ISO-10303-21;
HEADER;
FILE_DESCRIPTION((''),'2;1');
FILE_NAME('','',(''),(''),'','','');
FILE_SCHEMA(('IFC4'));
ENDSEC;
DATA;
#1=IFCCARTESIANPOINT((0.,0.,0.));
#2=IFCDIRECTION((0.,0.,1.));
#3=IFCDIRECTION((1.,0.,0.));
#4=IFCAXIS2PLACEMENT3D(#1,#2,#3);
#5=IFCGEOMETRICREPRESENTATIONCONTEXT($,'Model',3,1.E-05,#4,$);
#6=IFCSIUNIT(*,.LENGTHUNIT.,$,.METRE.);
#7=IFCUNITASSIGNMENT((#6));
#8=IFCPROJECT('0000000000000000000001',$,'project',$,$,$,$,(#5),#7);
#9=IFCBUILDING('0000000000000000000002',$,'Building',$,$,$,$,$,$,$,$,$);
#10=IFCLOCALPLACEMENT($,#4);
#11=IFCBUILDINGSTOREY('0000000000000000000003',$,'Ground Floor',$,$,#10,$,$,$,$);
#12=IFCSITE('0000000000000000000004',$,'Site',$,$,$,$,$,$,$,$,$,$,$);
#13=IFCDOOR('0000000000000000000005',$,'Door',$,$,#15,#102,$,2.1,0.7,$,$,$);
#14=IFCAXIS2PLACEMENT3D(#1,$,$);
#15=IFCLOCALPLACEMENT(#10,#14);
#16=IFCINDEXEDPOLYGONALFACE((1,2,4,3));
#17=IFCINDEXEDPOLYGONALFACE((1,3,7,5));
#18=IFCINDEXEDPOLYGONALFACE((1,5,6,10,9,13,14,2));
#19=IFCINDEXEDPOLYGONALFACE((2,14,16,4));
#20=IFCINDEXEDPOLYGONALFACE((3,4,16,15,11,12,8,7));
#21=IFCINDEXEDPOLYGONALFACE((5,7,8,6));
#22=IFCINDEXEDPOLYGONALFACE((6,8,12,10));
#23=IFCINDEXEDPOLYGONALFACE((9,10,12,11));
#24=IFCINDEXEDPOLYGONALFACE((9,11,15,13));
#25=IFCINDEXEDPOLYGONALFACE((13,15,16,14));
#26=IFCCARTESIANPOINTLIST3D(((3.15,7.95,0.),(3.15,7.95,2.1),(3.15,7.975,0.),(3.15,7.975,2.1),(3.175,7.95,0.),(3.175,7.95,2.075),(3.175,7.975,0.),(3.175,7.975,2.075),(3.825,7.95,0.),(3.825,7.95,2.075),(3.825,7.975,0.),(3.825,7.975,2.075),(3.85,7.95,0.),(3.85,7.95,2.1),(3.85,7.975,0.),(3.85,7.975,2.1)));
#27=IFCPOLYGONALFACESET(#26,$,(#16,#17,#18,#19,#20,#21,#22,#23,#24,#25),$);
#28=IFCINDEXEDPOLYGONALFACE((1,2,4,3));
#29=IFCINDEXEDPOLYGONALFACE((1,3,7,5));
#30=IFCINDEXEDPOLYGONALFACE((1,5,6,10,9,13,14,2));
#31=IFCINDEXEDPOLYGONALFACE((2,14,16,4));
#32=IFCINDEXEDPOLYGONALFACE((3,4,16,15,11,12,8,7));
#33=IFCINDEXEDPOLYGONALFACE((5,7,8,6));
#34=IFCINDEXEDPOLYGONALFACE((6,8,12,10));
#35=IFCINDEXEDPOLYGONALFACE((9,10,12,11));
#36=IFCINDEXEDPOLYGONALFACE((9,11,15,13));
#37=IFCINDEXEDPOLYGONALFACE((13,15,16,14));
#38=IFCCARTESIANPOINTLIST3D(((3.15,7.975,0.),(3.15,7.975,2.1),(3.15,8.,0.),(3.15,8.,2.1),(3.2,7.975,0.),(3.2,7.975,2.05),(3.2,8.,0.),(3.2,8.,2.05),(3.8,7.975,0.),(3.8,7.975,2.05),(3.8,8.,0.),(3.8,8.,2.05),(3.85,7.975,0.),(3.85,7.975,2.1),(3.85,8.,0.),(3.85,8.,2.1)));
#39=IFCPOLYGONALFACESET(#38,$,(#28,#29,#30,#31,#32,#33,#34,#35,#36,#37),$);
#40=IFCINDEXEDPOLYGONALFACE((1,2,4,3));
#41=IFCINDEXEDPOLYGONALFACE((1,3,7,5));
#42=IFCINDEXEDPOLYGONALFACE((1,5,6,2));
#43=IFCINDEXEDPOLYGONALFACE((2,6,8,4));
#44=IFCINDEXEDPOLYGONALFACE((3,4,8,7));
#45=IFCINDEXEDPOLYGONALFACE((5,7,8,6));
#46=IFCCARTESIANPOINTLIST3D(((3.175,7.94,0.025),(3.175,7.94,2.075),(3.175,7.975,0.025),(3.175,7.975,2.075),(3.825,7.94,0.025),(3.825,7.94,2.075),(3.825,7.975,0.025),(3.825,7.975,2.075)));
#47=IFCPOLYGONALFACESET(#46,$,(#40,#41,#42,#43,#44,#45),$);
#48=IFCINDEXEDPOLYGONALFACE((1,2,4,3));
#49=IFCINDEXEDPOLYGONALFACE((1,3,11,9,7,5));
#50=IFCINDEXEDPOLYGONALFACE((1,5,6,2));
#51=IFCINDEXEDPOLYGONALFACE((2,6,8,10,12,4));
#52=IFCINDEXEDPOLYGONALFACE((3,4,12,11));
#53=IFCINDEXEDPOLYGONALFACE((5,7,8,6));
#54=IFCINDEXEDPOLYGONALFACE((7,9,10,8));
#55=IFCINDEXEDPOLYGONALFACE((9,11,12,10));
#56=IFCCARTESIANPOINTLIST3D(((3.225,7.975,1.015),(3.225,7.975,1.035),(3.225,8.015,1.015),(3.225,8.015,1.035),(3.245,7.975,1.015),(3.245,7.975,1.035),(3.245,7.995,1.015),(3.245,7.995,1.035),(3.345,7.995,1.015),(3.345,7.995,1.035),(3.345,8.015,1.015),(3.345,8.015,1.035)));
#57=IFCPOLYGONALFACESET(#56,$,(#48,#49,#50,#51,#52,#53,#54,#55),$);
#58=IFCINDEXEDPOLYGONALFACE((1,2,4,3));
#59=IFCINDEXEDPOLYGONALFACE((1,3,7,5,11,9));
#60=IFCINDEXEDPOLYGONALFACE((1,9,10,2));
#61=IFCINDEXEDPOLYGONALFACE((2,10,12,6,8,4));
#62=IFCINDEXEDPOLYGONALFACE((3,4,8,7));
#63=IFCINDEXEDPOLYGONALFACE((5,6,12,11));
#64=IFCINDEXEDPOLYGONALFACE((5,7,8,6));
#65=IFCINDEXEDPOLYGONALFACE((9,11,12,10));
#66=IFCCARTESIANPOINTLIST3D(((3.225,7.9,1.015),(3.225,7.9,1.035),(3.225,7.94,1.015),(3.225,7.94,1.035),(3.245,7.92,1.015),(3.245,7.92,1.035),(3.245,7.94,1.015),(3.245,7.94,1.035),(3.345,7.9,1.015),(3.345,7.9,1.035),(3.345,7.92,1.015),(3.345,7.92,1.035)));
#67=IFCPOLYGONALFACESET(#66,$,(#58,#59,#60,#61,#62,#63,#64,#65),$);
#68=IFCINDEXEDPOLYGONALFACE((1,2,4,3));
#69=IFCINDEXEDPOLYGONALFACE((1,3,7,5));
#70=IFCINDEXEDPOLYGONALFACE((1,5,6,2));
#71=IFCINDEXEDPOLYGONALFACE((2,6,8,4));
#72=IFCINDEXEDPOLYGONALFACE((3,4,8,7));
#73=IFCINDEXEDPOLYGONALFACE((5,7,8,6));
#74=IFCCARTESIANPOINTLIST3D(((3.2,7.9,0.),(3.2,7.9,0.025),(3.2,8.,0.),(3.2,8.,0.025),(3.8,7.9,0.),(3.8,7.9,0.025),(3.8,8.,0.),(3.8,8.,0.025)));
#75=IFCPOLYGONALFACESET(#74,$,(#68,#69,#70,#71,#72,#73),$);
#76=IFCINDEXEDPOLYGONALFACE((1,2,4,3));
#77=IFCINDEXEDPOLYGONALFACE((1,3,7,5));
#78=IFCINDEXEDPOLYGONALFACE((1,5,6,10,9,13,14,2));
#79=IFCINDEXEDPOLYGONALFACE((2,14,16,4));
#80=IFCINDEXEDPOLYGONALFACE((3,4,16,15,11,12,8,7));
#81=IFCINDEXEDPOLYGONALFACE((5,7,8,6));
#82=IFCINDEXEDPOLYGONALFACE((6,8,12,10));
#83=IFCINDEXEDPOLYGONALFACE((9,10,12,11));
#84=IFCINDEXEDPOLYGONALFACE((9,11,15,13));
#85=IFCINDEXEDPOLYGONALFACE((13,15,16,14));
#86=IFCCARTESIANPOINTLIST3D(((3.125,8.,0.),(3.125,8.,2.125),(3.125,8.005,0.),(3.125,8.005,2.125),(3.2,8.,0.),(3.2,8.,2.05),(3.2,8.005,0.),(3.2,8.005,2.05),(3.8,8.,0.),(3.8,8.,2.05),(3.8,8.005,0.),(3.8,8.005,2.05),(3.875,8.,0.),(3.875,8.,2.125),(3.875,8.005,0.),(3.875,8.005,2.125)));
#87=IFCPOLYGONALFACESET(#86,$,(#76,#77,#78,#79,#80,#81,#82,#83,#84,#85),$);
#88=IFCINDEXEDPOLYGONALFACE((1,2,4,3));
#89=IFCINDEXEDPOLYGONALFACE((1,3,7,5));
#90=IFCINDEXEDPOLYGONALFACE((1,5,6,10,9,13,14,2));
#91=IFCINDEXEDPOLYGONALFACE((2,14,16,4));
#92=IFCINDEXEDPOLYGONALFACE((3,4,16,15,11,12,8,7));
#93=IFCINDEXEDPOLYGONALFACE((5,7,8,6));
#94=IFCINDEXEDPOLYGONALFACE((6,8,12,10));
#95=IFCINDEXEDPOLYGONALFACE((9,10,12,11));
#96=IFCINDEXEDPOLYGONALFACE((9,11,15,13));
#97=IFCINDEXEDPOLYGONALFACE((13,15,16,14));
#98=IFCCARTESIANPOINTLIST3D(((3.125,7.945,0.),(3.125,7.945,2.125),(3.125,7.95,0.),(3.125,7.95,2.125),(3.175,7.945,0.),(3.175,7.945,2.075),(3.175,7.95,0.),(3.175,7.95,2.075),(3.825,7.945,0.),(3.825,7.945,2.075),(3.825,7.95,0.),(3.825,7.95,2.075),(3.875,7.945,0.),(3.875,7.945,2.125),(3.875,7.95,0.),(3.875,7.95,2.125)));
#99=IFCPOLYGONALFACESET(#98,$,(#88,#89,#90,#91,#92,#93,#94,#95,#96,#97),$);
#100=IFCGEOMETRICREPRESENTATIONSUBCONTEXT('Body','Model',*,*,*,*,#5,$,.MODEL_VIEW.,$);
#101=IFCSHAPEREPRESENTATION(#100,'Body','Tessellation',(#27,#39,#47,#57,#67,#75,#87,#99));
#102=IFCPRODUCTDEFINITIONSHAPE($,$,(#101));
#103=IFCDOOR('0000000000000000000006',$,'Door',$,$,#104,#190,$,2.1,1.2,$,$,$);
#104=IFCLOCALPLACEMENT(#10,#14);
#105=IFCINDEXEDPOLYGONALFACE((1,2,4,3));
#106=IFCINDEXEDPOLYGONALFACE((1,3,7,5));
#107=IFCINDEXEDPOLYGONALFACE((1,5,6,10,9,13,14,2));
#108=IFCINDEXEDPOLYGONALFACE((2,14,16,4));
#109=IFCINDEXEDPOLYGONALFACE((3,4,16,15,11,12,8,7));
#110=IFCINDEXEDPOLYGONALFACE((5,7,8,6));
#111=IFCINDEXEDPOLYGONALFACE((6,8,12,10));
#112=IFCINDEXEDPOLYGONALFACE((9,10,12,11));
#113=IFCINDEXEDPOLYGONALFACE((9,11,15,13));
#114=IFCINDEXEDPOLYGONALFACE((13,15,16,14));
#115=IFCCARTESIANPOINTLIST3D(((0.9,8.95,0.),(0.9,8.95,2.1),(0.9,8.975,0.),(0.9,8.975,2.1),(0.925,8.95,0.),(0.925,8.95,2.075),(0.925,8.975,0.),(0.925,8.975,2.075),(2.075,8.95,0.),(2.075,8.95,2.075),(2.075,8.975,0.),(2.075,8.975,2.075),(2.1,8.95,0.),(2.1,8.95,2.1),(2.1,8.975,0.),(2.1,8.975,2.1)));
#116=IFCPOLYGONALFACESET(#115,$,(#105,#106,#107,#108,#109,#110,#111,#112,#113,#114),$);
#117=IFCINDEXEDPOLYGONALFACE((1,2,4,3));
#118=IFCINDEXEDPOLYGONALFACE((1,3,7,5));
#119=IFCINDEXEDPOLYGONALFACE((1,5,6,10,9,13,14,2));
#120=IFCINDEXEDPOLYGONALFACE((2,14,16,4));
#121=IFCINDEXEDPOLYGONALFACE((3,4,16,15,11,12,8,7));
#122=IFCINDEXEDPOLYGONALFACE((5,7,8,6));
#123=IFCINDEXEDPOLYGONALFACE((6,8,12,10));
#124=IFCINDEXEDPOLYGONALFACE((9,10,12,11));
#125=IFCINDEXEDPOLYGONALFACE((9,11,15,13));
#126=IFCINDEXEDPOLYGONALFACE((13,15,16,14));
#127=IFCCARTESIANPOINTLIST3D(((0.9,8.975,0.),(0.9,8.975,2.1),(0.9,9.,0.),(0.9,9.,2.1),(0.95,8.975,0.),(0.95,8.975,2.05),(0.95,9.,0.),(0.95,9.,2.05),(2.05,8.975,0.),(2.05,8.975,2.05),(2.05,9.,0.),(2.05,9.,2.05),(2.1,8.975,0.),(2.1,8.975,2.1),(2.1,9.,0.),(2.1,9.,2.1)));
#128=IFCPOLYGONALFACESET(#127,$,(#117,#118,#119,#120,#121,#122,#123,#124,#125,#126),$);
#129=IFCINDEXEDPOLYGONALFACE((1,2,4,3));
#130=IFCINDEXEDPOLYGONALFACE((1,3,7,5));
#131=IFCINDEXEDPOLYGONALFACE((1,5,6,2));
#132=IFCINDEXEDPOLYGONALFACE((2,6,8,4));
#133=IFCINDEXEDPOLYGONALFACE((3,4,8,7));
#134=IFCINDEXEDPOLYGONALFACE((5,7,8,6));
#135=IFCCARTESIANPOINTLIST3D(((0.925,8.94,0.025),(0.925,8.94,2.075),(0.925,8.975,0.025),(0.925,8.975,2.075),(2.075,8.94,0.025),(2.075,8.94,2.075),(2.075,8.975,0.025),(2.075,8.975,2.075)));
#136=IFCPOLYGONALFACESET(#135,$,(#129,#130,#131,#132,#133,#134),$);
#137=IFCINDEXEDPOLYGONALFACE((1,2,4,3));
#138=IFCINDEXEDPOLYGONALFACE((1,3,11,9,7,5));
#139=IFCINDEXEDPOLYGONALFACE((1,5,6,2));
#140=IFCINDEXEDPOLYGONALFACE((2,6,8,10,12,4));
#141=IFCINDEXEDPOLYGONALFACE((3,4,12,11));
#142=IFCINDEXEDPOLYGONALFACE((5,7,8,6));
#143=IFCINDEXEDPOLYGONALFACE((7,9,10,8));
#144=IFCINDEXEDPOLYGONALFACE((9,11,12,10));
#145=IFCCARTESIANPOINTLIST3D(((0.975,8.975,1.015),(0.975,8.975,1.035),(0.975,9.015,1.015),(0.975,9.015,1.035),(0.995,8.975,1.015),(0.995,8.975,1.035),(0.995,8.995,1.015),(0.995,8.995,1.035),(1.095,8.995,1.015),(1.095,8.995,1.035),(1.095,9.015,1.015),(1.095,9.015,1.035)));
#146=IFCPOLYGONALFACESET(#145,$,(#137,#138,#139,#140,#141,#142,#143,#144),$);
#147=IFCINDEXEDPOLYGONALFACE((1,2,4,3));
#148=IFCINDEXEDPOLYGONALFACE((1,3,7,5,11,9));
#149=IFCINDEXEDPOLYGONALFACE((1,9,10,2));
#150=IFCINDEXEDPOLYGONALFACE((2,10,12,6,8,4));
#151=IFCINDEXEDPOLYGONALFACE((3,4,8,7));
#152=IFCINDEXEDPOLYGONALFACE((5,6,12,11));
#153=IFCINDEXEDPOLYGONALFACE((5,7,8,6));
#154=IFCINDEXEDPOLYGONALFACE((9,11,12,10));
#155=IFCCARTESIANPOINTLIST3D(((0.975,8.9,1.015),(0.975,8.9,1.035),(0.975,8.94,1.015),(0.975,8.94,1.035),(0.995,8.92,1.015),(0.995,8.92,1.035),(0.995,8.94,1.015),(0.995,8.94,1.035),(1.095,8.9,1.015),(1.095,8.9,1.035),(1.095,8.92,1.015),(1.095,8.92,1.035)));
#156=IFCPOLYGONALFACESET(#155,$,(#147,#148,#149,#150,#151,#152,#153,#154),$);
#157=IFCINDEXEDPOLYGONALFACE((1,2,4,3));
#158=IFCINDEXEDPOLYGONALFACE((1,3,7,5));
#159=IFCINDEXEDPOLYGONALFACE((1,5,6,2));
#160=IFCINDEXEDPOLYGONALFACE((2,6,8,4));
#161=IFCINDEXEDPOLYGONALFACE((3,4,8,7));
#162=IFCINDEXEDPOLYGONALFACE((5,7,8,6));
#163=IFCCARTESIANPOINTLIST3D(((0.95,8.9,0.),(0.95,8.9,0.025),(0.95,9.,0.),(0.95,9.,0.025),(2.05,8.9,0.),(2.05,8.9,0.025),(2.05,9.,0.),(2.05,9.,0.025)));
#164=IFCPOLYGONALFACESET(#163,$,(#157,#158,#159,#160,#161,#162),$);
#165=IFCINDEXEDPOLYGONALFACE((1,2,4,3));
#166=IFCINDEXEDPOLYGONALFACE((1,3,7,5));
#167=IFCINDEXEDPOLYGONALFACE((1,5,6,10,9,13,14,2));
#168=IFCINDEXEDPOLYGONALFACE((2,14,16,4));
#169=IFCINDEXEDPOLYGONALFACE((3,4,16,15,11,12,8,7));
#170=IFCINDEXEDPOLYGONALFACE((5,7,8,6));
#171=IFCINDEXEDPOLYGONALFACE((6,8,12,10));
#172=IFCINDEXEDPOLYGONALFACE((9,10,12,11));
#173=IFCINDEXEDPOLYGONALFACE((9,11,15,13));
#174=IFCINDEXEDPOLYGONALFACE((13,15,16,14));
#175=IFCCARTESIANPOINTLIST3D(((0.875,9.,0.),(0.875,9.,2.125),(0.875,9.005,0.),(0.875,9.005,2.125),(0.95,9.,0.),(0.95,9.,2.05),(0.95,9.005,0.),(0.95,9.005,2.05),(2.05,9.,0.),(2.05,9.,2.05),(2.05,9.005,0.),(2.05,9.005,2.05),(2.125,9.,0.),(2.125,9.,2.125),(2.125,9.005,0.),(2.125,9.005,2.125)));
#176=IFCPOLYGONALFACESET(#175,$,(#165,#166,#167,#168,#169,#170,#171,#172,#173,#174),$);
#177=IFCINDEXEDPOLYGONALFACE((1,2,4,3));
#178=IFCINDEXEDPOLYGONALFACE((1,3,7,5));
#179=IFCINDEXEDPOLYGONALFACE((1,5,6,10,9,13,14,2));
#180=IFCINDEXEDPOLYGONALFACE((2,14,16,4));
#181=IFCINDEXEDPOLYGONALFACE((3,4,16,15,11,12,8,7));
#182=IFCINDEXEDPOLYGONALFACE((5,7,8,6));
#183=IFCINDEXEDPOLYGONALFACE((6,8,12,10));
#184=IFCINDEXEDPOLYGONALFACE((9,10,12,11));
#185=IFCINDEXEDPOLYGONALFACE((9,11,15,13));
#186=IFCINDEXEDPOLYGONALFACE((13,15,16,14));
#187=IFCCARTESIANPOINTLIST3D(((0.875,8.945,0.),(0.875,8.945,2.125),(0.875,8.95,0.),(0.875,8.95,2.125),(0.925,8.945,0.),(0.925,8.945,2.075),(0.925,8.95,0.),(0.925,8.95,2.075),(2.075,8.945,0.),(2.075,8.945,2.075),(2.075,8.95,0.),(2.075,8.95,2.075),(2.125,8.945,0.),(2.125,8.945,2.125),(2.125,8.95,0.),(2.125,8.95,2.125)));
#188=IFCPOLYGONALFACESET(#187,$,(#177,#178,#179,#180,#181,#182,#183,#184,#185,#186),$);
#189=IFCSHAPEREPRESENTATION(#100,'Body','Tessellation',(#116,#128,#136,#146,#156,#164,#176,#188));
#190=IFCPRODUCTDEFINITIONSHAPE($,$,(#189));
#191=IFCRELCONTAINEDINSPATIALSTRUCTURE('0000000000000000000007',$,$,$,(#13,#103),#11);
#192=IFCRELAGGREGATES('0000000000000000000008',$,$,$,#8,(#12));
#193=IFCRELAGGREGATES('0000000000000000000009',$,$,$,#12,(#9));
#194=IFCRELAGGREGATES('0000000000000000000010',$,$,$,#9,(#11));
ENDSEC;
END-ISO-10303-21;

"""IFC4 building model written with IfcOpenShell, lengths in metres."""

from ifc_helpers import new_model, si_unit, frame, origin_with_axes, place, context, subcontext, project, spatial, line, indexed_curve, outline, extrude, element, save


model = new_model("IFC4")

# Units and contexts
model_context = context("Model", 3, precision=1e-05, world=origin_with_axes())
body_context = subcontext(model_context, "Body", "Model", "MODEL_VIEW")
ifc_project = project(units=[si_unit("LENGTHUNIT", "METRE")], contexts=[model_context])

# Site, building, storey
site = spatial("IfcSite", under=ifc_project, Name="Site")
building = spatial("IfcBuilding", under=site, Name="Building")
storey_placement = place(None, origin_with_axes())
storey = spatial("IfcBuildingStorey", under=building, at=storey_placement, Name="Ground Floor")

# Doors
door_1_placement = place(storey_placement, frame((3.85, 8.0, 0.0), z_axis=(0.0, 0.0, 1.0), x_axis=(-1.0, 0.0, 0.0)))
element("IfcDoor", 1, at=door_1_placement, inside=storey, Name="Door", OverallHeight=2.1, OverallWidth=0.7, context=body_context, shape_type="SweptSolid", body=[
    extrude(outline(indexed_curve([(0.0, 0.0), (0.0, 2.1), (0.7, 2.1), (0.7, 0.0), (0.675, 0.0), (0.675, 2.075), (0.025, 2.075), (0.025, 0.0)], segments=[line(1, 2, 3, 4, 5, 6, 7, 8, 1)])), frame((0.0, 0.025, 0.0), z_axis=(0.0, -1.0, 0.0), x_axis=(1.0, 0.0, 0.0)), (0.0, 0.0, -1.0), 0.025),
    extrude(outline(indexed_curve([(0.0, 0.0), (0.0, 2.1), (0.7, 2.1), (0.7, 0.0), (0.65, 0.0), (0.65, 2.05), (0.05, 2.05), (0.05, 0.0)], segments=[line(1, 2, 3, 4, 5, 6, 7, 8, 1)])), frame((0.0, 0.0, 0.0), z_axis=(0.0, -1.0, 0.0), x_axis=(1.0, 0.0, 0.0)), (0.0, 0.0, -1.0), 0.025),
    extrude(outline(indexed_curve([(0.0, 0.0), (0.65, 0.0), (0.65, 0.035), (0.0, 0.035)], segments=[line(1, 2, 3, 4, 1)])), frame((0.025, 0.025, 0.025), z_axis=(0.0, 0.0, 1.0), x_axis=(1.0, 0.0, 0.0)), (0.0, 0.0, 1.0), 2.05),
    extrude(outline(indexed_curve([(0.0, 0.0), (0.0, -0.04), (-0.12, -0.04), (-0.12, -0.02), (-0.02, -0.02), (-0.02, 0.0)], segments=[line(1, 2, 3, 4, 5, 6, 1)])), frame((0.625, 0.025, 1.015), z_axis=(0.0, 0.0, 1.0), x_axis=(1.0, 0.0, 0.0)), (0.0, 0.0, 1.0), 0.02),
    extrude(outline(indexed_curve([(0.0, 0.0), (0.0, 0.04), (-0.12, 0.04), (-0.12, 0.02), (-0.02, 0.02), (-0.02, 0.0)], segments=[line(1, 2, 3, 4, 5, 6, 1)])), frame((0.625, 0.06, 1.015), z_axis=(0.0, 0.0, 1.0), x_axis=(1.0, 0.0, 0.0)), (0.0, 0.0, 1.0), 0.02),
    extrude(outline(indexed_curve([(0.0, 0.0), (0.6, 0.0), (0.6, 0.1), (0.0, 0.1)], segments=[line(1, 2, 3, 4, 1)])), frame((0.05, 0.0, 0.0), z_axis=(0.0, 0.0, 1.0), x_axis=(1.0, 0.0, 0.0)), (0.0, 0.0, 1.0), 0.025),
    extrude(outline(indexed_curve([(0.0, 0.0), (0.0, 2.125), (0.75, 2.125), (0.75, 0.0), (0.675, 0.0), (0.675, 2.05), (0.075, 2.05), (0.075, 0.0)], segments=[line(1, 2, 3, 4, 5, 6, 7, 8, 1)])), frame((-0.025, -0.005, 0.0), z_axis=(0.0, -1.0, 0.0), x_axis=(1.0, 0.0, 0.0)), (0.0, 0.0, -1.0), 0.005),
    extrude(outline(indexed_curve([(0.0, 0.0), (0.0, 2.125), (0.75, 2.125), (0.75, 0.0), (0.7, 0.0), (0.7, 2.075), (0.05, 2.075), (0.05, 0.0)], segments=[line(1, 2, 3, 4, 5, 6, 7, 8, 1)])), frame((-0.025, 0.05, 0.0), z_axis=(0.0, -1.0, 0.0), x_axis=(1.0, 0.0, 0.0)), (0.0, 0.0, -1.0), 0.005),
])
door_2_placement = place(storey_placement, frame((2.1, 9.0, 0.0), z_axis=(0.0, 0.0, 1.0), x_axis=(-1.0, 0.0, 0.0)))
element("IfcDoor", 2, at=door_2_placement, inside=storey, Name="Door", OverallHeight=2.1, OverallWidth=1.2, context=body_context, shape_type="SweptSolid", body=[
    extrude(outline(indexed_curve([(0.0, 0.0), (0.0, 2.1), (1.2, 2.1), (1.2, 0.0), (1.175, 0.0), (1.175, 2.075), (0.025, 2.075), (0.025, 0.0)], segments=[line(1, 2, 3, 4, 5, 6, 7, 8, 1)])), frame((0.0, 0.025, 0.0), z_axis=(0.0, -1.0, 0.0), x_axis=(1.0, 0.0, 0.0)), (0.0, 0.0, -1.0), 0.025),
    extrude(outline(indexed_curve([(0.0, 0.0), (0.0, 2.1), (1.2, 2.1), (1.2, 0.0), (1.15, 0.0), (1.15, 2.05), (0.05, 2.05), (0.05, 0.0)], segments=[line(1, 2, 3, 4, 5, 6, 7, 8, 1)])), frame((0.0, 0.0, 0.0), z_axis=(0.0, -1.0, 0.0), x_axis=(1.0, 0.0, 0.0)), (0.0, 0.0, -1.0), 0.025),
    extrude(outline(indexed_curve([(0.0, 0.0), (1.15, 0.0), (1.15, 0.035), (0.0, 0.035)], segments=[line(1, 2, 3, 4, 1)])), frame((0.025, 0.025, 0.025), z_axis=(0.0, 0.0, 1.0), x_axis=(1.0, 0.0, 0.0)), (0.0, 0.0, 1.0), 2.05),
    extrude(outline(indexed_curve([(0.0, 0.0), (0.0, -0.04), (-0.12, -0.04), (-0.12, -0.02), (-0.02, -0.02), (-0.02, 0.0)], segments=[line(1, 2, 3, 4, 5, 6, 1)])), frame((1.125, 0.025, 1.015), z_axis=(0.0, 0.0, 1.0), x_axis=(1.0, 0.0, 0.0)), (0.0, 0.0, 1.0), 0.02),
    extrude(outline(indexed_curve([(0.0, 0.0), (0.0, 0.04), (-0.12, 0.04), (-0.12, 0.02), (-0.02, 0.02), (-0.02, 0.0)], segments=[line(1, 2, 3, 4, 5, 6, 1)])), frame((1.125, 0.06, 1.015), z_axis=(0.0, 0.0, 1.0), x_axis=(1.0, 0.0, 0.0)), (0.0, 0.0, 1.0), 0.02),
    extrude(outline(indexed_curve([(0.0, 0.0), (1.1, 0.0), (1.1, 0.1), (0.0, 0.1)], segments=[line(1, 2, 3, 4, 1)])), frame((0.05, 0.0, 0.0), z_axis=(0.0, 0.0, 1.0), x_axis=(1.0, 0.0, 0.0)), (0.0, 0.0, 1.0), 0.025),
    extrude(outline(indexed_curve([(0.0, 0.0), (0.0, 2.125), (1.25, 2.125), (1.25, 0.0), (1.175, 0.0), (1.175, 2.05), (0.075, 2.05), (0.075, 0.0)], segments=[line(1, 2, 3, 4, 5, 6, 7, 8, 1)])), frame((-0.025, -0.005, 0.0), z_axis=(0.0, -1.0, 0.0), x_axis=(1.0, 0.0, 0.0)), (0.0, 0.0, -1.0), 0.005),
    extrude(outline(indexed_curve([(0.0, 0.0), (0.0, 2.125), (1.25, 2.125), (1.25, 0.0), (1.2, 0.0), (1.2, 2.075), (0.05, 2.075), (0.05, 0.0)], segments=[line(1, 2, 3, 4, 5, 6, 7, 8, 1)])), frame((-0.025, 0.05, 0.0), z_axis=(0.0, -1.0, 0.0), x_axis=(1.0, 0.0, 0.0)), (0.0, 0.0, -1.0), 0.005),
])

save(model, "model.ifc")
